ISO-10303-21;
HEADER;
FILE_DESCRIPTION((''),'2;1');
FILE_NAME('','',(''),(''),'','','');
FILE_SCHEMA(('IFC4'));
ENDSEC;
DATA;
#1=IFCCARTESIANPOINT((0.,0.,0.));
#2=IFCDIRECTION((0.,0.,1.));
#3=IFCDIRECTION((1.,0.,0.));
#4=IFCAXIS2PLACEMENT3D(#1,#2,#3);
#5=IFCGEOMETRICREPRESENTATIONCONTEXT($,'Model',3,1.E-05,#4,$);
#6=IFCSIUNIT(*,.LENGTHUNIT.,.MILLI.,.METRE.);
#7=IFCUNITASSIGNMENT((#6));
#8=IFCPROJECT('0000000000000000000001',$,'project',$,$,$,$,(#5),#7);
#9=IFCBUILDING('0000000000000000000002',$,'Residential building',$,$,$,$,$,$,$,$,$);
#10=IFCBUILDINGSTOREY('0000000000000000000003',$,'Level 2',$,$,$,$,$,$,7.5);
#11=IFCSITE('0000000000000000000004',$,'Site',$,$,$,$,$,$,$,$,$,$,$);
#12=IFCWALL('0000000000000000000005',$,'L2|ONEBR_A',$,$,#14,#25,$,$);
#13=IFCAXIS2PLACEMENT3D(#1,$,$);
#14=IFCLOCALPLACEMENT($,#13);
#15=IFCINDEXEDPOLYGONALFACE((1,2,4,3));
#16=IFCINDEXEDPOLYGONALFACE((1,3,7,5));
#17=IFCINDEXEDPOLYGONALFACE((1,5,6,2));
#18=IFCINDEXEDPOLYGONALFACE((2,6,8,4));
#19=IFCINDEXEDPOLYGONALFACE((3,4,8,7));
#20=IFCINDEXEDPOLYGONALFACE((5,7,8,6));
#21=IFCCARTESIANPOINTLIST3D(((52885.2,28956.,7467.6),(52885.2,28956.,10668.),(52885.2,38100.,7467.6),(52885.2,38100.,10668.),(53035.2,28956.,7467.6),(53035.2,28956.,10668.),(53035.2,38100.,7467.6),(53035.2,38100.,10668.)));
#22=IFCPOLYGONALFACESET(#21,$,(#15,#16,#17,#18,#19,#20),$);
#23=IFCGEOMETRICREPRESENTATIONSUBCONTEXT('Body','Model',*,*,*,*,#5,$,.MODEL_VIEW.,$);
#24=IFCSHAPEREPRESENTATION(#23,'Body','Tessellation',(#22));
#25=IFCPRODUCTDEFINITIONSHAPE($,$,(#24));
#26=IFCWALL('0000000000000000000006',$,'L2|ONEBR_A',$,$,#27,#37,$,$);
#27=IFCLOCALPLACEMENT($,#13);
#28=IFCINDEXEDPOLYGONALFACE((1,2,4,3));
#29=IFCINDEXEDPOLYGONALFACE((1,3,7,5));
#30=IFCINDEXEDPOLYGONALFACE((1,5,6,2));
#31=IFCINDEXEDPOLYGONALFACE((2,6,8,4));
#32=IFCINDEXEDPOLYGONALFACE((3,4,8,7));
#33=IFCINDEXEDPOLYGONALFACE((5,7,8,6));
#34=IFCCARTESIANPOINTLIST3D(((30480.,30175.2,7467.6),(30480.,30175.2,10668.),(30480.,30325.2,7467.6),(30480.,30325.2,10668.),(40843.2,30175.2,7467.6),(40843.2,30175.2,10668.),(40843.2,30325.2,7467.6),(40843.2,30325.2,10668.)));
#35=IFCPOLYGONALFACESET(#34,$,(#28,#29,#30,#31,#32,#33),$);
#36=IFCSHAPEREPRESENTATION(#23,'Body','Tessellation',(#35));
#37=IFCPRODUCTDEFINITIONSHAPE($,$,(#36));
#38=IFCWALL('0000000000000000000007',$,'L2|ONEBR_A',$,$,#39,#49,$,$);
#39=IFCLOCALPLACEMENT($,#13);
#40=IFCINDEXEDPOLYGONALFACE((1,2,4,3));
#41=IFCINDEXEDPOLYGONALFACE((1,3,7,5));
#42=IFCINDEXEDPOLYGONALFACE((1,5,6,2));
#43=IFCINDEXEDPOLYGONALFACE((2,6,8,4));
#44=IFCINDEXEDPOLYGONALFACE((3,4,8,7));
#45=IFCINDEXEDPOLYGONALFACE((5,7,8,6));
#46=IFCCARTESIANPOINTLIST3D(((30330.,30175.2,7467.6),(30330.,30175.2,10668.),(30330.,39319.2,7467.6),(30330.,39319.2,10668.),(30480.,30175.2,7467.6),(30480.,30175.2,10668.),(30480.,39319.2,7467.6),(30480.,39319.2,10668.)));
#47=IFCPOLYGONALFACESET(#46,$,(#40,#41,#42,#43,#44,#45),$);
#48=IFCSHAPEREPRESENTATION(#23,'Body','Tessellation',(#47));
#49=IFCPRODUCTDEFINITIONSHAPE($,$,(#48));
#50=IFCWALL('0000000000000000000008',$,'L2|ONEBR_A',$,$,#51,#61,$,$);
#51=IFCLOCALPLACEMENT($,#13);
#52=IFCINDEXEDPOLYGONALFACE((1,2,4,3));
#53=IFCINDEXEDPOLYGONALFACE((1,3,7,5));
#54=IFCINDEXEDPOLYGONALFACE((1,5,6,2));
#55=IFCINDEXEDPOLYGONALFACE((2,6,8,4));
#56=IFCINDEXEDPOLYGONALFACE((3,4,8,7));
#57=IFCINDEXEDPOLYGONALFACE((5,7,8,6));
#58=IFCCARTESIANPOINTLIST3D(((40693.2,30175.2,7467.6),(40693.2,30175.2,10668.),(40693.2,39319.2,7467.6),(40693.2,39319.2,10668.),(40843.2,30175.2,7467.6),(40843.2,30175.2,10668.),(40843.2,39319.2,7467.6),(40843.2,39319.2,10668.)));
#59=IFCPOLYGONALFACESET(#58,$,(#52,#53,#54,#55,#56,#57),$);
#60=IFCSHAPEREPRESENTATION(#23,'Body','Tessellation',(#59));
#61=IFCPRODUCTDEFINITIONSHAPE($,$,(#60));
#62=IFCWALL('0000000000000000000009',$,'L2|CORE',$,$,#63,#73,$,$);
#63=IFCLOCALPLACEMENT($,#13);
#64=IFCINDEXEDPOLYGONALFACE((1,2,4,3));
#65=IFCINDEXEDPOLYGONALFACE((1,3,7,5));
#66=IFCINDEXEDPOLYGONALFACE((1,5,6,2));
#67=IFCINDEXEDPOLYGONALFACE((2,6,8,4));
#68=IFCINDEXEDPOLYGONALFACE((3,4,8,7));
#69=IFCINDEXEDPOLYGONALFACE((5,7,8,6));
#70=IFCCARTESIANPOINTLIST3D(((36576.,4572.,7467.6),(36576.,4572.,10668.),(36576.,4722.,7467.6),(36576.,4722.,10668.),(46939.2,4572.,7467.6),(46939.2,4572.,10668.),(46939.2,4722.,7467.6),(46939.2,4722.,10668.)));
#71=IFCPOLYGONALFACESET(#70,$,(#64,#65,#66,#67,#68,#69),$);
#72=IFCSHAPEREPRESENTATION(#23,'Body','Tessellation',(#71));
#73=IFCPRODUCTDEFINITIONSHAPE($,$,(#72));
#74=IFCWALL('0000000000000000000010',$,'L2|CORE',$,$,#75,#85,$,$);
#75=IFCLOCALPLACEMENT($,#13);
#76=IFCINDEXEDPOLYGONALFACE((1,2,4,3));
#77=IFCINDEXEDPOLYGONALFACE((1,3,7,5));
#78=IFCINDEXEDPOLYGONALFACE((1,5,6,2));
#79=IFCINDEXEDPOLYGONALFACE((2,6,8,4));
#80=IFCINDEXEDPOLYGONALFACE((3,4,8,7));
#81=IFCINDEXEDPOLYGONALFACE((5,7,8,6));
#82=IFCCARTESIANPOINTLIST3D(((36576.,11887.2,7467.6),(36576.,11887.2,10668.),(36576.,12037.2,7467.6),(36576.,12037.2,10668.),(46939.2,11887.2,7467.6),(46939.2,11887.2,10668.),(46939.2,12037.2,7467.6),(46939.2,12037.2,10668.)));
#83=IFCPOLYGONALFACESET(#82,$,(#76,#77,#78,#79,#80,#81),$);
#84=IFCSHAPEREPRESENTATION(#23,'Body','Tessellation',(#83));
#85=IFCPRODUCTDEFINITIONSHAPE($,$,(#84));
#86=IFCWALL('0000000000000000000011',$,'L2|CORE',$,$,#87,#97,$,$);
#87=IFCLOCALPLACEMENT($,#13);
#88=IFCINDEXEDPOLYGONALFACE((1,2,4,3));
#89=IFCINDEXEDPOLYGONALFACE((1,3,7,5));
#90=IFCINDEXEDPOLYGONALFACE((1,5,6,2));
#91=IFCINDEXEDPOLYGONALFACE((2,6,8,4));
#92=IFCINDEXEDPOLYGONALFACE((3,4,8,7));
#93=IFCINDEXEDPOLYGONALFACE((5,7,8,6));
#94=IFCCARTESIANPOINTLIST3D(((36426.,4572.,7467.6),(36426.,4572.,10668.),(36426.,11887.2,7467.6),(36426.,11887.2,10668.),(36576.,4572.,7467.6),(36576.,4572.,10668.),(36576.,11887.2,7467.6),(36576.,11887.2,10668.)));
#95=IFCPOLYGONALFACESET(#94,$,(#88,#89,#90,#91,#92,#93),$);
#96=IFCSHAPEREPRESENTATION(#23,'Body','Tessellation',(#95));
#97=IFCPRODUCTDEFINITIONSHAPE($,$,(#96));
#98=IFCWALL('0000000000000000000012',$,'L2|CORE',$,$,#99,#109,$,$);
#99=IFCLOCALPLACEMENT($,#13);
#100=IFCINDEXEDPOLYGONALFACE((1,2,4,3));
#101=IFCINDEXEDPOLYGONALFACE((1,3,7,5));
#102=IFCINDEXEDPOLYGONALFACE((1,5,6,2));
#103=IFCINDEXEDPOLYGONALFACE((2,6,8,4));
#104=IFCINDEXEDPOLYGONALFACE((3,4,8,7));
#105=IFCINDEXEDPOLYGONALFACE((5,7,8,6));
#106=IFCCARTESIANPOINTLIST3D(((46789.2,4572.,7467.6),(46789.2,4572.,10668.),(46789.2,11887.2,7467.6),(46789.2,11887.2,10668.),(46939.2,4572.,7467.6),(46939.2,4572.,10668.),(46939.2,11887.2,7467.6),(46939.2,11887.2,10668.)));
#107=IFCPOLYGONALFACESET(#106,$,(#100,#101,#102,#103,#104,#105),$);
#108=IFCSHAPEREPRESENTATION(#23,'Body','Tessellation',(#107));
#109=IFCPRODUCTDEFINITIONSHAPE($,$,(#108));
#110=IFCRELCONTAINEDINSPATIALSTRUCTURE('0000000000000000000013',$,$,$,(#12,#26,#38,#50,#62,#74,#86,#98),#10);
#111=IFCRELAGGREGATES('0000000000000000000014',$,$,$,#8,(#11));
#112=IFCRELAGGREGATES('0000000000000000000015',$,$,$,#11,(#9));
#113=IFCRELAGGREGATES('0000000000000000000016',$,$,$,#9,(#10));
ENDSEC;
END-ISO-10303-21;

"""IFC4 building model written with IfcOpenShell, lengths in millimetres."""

from ifc_helpers import new_model, si_unit, frame, origin_with_axes, place, context, subcontext, project, spatial, indexed_curve, outline, extrude, element, save


model = new_model("IFC4")

# Units and contexts
model_context = context("Model", 3, precision=1e-05, world=origin_with_axes())
body_context = subcontext(model_context, "Body", "Model", "MODEL_VIEW")
ifc_project = project(units=[si_unit("LENGTHUNIT", "METRE", prefix="MILLI")], contexts=[model_context])

# Site, building, storey
site = spatial("IfcSite", under=ifc_project, Name="Site")
building = spatial("IfcBuilding", under=site, Name="Residential building")
storey = spatial("IfcBuildingStorey", under=building, Name="Level 2", Elevation=7.5)

# Walls
for number, where, z_axis, x_axis, name in (
    (1, (53035.2, 28956.0, 7467.6), (0.0, 0.0, 1.0), (0.0, 1.0, 0.0), "L2|ONEBR_A"),
):
    element("IfcWall", number, at=place(None, frame(where, z_axis=z_axis, x_axis=x_axis)), inside=storey, Name=name, context=body_context, shape_type="SweptSolid", body=[
        extrude(outline(indexed_curve([(0.0, 0.0), (0.0, 150.0), (9144.0, 150.0), (9144.0, 0.0), (0.0, 0.0)], self_intersect=False)), origin_with_axes(), (0.0, 0.0, 1.0), 3200.4),
    ])
wall_1_placement = place(None, frame((30480.0, 30175.2, 7467.6), z_axis=(0.0, 0.0, 1.0), x_axis=(1.0, 0.0, 0.0)))
element("IfcWall", 2, at=wall_1_placement, inside=storey, Name="L2|ONEBR_A", context=body_context, shape_type="SweptSolid", body=[
    extrude(outline(indexed_curve([(0.0, 0.0), (0.0, 150.0), (10363.2, 150.0), (10363.2, 0.0), (0.0, 0.0)], self_intersect=False)), origin_with_axes(), (0.0, 0.0, 1.0), 3200.4),
])
for number, where, z_axis, x_axis, name in (
    (3, (30480.0, 30175.2, 7467.6), (0.0, 0.0, 1.0), (0.0, 1.0, 0.0), "L2|ONEBR_A"),
    (4, (40843.2, 30175.2, 7467.6), (0.0, 0.0, 1.0), (0.0, 1.0, 0.0), "L2|ONEBR_A"),
):
    element("IfcWall", number, at=place(None, frame(where, z_axis=z_axis, x_axis=x_axis)), inside=storey, Name=name, context=body_context, shape_type="SweptSolid", body=[
        extrude(outline(indexed_curve([(0.0, 0.0), (0.0, 150.0), (9144.0, 150.0), (9144.0, 0.0), (0.0, 0.0)], self_intersect=False)), origin_with_axes(), (0.0, 0.0, 1.0), 3200.4),
    ])
for number, where, z_axis, x_axis, name in (
    (5, (36576.0, 4572.0, 7467.6), (0.0, 0.0, 1.0), (1.0, 0.0, 0.0), "L2|CORE"),
    (6, (36576.0, 11887.2, 7467.6), (0.0, 0.0, 1.0), (1.0, 0.0, 0.0), "L2|CORE"),
):
    element("IfcWall", number, at=place(None, frame(where, z_axis=z_axis, x_axis=x_axis)), inside=storey, Name=name, context=body_context, shape_type="SweptSolid", body=[
        extrude(outline(indexed_curve([(0.0, 0.0), (0.0, 150.0), (10363.2, 150.0), (10363.2, 0.0), (0.0, 0.0)], self_intersect=False)), origin_with_axes(), (0.0, 0.0, 1.0), 3200.4),
    ])
for number, where, z_axis, x_axis, name in (
    (7, (36576.0, 4572.0, 7467.6), (0.0, 0.0, 1.0), (0.0, 1.0, 0.0), "L2|CORE"),
    (8, (46939.2, 4572.0, 7467.6), (0.0, 0.0, 1.0), (0.0, 1.0, 0.0), "L2|CORE"),
):
    element("IfcWall", number, at=place(None, frame(where, z_axis=z_axis, x_axis=x_axis)), inside=storey, Name=name, context=body_context, shape_type="SweptSolid", body=[
        extrude(outline(indexed_curve([(0.0, 0.0), (0.0, 150.0), (7315.2, 150.0), (7315.2, 0.0), (0.0, 0.0)], self_intersect=False)), origin_with_axes(), (0.0, 0.0, 1.0), 3200.4),
    ])

save(model, "model.ifc")
